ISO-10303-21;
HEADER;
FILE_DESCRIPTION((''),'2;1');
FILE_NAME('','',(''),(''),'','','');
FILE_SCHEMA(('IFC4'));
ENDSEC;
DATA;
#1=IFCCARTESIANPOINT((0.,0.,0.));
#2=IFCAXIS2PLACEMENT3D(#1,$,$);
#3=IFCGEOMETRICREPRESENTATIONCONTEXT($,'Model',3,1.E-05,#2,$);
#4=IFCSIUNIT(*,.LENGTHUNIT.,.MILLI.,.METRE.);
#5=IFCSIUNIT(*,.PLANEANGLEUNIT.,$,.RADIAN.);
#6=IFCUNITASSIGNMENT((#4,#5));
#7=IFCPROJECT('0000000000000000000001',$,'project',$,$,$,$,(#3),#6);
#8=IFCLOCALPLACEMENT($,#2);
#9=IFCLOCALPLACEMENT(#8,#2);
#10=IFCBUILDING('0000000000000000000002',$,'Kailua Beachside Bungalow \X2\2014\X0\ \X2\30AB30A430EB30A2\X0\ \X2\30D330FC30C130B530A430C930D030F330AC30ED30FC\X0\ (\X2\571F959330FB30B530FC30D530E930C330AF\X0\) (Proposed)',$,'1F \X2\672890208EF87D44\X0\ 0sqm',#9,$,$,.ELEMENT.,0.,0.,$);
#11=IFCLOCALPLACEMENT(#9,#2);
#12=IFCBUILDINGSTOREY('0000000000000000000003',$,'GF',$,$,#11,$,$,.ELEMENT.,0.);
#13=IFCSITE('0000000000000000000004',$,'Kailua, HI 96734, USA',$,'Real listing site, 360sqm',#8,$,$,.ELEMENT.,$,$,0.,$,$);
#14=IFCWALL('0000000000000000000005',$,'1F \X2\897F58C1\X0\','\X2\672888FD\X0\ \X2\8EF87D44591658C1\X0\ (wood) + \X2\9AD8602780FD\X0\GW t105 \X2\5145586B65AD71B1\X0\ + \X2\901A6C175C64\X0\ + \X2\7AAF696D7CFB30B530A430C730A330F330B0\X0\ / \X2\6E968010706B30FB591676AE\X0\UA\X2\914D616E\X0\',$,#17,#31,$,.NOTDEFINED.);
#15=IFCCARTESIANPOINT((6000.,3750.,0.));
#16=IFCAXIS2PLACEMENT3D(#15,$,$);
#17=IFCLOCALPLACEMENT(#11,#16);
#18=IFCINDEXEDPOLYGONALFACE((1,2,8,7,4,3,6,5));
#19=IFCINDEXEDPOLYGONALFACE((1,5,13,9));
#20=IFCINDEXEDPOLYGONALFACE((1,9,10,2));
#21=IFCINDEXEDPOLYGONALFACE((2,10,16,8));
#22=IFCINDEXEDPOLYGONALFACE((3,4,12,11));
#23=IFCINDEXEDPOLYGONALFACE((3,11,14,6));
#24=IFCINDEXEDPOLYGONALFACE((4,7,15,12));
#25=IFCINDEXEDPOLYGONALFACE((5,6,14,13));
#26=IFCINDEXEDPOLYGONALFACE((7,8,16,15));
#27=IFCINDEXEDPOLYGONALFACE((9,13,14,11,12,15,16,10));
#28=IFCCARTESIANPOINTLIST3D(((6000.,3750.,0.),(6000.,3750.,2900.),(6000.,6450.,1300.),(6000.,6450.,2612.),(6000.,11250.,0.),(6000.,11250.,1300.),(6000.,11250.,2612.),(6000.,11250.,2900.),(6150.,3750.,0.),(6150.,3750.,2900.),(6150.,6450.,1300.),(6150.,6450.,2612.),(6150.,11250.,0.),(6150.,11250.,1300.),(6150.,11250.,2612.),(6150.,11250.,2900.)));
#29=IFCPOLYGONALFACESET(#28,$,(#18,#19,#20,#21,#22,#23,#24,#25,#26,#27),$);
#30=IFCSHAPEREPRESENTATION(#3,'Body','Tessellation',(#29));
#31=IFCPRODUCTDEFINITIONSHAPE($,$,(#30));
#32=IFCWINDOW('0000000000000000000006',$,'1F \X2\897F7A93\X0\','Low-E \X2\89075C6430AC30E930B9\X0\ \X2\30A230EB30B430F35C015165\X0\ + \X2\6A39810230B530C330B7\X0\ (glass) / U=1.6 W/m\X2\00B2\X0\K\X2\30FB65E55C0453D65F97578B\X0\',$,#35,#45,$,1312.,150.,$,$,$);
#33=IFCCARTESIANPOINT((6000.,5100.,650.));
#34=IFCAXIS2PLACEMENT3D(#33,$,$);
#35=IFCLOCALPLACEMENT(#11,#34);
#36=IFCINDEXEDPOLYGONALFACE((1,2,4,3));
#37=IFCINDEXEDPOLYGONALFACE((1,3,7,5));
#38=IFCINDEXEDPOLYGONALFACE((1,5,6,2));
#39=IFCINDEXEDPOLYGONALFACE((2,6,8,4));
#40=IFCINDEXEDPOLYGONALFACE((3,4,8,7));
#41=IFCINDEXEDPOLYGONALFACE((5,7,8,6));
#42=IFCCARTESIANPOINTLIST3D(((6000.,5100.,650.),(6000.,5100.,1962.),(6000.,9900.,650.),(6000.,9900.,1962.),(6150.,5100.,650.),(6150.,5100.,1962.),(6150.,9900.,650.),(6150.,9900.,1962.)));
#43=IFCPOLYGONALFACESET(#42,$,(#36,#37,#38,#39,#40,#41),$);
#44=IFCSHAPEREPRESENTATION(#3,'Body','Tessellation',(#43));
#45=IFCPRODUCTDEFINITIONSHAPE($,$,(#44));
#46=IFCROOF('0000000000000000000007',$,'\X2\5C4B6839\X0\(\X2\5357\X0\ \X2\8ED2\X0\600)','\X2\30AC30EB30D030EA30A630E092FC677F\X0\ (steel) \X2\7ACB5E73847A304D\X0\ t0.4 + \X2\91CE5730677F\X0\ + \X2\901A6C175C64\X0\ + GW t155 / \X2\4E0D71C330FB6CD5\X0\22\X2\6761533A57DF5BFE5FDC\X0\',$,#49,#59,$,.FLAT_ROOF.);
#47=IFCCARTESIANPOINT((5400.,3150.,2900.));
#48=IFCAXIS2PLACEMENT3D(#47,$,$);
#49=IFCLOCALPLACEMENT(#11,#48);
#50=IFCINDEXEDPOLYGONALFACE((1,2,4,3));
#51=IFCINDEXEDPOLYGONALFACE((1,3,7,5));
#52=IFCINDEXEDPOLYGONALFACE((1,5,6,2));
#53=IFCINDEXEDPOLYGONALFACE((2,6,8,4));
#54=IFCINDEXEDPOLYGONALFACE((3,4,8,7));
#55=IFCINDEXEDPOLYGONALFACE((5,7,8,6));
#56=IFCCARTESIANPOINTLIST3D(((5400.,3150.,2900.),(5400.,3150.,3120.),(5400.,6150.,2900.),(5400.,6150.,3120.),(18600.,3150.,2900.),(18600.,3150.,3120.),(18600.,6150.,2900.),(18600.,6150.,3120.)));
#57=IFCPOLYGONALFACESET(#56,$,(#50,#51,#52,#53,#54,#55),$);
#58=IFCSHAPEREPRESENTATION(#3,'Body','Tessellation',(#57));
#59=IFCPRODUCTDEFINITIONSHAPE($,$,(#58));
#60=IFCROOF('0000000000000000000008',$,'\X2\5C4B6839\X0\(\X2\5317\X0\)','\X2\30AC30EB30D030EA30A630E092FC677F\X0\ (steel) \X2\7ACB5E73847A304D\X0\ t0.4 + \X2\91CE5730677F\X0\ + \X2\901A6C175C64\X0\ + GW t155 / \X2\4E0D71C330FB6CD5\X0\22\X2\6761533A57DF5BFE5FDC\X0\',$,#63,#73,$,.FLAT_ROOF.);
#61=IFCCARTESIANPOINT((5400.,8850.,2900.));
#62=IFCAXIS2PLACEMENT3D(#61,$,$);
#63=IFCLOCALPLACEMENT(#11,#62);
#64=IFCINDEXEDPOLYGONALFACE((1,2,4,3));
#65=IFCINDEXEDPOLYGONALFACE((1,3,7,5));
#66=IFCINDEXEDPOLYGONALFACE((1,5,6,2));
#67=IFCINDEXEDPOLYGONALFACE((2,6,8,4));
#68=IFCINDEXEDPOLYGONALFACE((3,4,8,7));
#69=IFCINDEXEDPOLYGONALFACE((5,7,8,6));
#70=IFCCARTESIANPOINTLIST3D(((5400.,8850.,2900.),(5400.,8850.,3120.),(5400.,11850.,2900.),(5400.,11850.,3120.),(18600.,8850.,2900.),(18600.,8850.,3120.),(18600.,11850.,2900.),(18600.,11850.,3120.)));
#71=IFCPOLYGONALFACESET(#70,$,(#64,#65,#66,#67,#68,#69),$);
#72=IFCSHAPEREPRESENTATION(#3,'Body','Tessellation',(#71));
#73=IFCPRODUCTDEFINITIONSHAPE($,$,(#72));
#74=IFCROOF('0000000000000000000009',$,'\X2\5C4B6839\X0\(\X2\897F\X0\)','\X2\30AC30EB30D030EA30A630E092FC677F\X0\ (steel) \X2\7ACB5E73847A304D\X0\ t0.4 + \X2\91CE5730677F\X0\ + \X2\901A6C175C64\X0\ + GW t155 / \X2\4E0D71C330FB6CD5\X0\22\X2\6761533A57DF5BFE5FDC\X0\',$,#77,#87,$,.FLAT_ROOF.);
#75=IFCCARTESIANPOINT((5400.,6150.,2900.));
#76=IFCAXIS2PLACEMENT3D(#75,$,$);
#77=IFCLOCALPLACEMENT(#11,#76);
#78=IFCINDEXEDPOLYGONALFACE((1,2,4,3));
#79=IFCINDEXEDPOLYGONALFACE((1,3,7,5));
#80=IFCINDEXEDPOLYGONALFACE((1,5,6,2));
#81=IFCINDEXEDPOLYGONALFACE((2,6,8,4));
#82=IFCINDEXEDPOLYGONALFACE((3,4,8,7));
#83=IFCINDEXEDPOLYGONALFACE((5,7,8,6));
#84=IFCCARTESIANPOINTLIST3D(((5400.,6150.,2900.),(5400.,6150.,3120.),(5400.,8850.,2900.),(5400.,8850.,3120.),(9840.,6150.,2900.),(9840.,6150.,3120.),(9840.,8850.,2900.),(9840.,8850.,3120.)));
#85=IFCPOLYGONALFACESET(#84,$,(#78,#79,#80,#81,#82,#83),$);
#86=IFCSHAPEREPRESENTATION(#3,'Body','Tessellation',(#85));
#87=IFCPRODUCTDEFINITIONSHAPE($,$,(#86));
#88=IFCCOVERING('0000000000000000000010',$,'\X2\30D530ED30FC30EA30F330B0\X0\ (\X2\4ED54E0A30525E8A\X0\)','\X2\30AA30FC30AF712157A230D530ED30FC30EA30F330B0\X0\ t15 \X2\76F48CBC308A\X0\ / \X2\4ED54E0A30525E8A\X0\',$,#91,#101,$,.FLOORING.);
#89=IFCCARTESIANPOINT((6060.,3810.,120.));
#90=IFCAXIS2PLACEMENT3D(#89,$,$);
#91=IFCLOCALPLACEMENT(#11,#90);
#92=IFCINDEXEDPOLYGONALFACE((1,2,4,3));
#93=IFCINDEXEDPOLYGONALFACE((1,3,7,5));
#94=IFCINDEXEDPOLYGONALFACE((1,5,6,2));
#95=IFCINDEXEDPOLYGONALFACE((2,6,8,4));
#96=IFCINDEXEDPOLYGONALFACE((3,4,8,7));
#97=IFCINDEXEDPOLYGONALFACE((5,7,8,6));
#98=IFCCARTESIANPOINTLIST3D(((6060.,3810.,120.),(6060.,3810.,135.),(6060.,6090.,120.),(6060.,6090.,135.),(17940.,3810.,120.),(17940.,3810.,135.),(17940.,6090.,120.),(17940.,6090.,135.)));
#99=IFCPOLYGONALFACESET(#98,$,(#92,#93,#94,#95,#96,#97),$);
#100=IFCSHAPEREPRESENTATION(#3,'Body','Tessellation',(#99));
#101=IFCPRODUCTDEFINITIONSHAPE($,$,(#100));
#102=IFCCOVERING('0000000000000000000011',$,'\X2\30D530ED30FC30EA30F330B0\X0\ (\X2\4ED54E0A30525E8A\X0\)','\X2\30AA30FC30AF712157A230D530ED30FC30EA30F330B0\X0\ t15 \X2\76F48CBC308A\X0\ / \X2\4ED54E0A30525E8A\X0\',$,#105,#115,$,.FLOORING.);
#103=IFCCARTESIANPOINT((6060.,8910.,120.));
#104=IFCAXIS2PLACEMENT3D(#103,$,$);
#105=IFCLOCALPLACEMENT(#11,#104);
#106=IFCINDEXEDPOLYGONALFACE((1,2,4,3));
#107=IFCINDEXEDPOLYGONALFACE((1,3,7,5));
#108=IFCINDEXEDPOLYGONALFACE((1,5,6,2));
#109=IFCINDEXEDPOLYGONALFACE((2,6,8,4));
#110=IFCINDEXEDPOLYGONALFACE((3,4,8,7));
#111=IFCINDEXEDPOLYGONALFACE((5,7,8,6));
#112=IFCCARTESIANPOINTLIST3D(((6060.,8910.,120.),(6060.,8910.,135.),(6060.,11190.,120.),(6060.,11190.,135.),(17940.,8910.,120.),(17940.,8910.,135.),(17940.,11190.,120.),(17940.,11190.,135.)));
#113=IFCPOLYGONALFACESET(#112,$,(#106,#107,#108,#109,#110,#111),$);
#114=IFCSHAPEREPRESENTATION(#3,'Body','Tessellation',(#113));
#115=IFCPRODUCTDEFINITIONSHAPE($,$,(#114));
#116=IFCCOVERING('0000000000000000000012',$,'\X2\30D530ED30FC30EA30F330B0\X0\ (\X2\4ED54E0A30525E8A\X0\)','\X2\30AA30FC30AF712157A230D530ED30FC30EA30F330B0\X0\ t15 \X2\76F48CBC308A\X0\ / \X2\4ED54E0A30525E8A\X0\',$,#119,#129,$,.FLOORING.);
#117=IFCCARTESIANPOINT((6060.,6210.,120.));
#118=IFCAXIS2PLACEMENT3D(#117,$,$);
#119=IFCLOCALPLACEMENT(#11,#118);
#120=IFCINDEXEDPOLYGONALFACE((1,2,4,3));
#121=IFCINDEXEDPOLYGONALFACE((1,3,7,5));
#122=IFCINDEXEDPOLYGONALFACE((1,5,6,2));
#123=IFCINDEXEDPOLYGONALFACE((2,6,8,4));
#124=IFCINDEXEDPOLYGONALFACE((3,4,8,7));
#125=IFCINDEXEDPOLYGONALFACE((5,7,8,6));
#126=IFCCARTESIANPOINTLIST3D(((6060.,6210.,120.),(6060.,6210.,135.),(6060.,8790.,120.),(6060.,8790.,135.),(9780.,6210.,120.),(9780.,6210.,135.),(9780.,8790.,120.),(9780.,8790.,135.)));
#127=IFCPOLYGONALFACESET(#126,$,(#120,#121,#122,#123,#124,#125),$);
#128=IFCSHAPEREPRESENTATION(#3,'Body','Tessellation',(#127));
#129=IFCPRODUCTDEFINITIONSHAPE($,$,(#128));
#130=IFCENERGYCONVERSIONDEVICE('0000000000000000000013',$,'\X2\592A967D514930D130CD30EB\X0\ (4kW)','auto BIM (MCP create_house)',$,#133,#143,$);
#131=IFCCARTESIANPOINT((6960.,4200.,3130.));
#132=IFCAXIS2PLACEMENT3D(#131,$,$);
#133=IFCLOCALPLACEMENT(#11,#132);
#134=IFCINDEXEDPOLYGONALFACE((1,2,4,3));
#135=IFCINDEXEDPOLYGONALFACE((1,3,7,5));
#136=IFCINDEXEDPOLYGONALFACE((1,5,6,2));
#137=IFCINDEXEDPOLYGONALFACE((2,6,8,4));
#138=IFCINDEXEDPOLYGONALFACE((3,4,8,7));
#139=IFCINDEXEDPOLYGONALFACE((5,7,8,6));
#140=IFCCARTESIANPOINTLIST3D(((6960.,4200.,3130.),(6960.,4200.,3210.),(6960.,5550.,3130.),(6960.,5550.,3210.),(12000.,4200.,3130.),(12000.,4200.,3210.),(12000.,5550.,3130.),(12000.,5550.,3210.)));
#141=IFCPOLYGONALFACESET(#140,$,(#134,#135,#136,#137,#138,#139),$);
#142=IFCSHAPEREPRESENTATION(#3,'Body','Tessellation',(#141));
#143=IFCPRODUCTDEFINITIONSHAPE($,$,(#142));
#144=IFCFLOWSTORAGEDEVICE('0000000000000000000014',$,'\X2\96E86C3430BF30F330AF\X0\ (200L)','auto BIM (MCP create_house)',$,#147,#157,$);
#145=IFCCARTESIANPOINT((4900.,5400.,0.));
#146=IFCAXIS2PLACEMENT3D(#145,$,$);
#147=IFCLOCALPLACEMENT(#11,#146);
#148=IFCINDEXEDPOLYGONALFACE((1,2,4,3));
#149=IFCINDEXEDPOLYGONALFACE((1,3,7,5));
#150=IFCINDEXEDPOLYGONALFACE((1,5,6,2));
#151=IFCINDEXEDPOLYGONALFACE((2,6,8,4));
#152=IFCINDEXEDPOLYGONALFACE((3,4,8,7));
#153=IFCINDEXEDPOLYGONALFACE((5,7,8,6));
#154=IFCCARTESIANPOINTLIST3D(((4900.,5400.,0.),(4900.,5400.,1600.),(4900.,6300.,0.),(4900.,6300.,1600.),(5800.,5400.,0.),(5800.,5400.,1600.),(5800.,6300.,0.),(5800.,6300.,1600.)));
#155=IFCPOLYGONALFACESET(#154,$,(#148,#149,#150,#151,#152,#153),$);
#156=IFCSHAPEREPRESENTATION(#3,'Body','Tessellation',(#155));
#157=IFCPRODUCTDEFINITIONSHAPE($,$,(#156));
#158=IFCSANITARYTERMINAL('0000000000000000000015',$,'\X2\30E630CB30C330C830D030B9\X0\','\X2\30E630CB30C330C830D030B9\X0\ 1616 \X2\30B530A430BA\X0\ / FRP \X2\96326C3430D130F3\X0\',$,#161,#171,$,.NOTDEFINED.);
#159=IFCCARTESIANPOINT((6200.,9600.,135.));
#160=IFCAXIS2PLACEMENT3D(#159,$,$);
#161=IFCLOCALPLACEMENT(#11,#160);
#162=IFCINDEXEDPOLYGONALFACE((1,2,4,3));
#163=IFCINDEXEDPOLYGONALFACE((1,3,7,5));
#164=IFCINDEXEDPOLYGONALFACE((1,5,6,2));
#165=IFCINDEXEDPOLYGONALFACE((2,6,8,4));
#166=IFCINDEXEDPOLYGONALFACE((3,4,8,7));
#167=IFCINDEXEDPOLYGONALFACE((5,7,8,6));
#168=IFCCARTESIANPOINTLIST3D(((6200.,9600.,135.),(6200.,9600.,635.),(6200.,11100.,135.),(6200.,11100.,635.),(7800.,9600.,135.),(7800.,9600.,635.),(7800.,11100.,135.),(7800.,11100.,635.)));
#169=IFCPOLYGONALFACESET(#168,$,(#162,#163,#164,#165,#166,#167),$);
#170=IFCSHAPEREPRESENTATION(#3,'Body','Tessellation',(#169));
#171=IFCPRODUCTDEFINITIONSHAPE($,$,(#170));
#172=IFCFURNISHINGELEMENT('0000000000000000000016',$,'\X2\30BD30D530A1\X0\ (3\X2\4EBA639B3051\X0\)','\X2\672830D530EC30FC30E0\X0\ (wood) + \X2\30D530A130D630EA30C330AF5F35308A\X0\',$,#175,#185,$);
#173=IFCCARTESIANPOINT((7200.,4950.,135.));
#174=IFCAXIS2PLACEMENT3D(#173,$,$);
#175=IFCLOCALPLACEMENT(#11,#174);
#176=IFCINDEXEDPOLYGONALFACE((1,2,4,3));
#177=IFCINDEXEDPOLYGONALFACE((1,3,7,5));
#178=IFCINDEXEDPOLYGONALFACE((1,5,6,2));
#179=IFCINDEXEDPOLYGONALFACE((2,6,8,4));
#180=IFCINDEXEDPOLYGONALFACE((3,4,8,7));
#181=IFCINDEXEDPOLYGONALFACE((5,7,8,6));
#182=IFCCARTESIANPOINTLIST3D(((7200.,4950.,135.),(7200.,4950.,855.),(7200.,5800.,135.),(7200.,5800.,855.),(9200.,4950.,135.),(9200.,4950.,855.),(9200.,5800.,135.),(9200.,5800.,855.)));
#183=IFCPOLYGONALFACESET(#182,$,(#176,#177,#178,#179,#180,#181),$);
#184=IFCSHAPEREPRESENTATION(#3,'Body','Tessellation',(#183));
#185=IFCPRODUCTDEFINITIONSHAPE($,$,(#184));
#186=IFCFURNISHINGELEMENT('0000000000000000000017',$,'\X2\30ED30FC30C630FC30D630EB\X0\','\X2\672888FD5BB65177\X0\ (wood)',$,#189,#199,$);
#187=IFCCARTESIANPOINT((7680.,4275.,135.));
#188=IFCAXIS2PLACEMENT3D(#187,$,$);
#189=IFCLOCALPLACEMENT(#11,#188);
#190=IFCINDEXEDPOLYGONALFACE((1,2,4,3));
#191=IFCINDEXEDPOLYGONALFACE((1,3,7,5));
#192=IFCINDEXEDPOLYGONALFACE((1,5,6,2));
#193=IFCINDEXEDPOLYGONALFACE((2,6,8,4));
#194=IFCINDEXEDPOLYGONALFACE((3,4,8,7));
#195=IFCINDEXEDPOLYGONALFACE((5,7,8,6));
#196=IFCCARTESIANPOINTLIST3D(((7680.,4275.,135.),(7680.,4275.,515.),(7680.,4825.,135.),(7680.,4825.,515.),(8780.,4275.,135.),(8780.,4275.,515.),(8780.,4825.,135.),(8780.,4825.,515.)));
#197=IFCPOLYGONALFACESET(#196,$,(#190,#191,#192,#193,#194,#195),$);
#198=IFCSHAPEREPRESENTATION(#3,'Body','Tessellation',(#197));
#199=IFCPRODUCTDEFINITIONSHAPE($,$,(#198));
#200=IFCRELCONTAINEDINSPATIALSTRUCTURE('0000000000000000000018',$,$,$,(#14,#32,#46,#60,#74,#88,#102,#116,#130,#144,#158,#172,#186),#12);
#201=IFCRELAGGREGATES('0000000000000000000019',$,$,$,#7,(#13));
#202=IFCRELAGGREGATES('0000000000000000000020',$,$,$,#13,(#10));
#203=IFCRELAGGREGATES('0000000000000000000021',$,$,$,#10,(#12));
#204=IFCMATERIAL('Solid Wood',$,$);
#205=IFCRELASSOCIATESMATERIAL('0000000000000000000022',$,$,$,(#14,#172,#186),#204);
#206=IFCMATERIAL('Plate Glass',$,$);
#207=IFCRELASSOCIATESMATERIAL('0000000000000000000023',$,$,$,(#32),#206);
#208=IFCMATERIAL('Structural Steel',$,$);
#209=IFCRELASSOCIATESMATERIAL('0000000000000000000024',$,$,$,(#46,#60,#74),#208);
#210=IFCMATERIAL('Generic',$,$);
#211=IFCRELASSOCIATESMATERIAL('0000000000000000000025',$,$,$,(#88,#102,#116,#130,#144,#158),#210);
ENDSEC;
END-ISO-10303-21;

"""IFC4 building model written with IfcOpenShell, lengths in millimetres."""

from ifc_helpers import new_model, si_unit, frame, frame_2d, origin, place, context, project, spatial, rectangle, extrude, material, element, fill, save


model = new_model("IFC4")

# Units and contexts
model_context = context("Model", 3, precision=1e-05, world=origin())
ifc_project = project(units=[si_unit("LENGTHUNIT", "METRE", prefix="MILLI"), si_unit("PLANEANGLEUNIT", "RADIAN")], contexts=[model_context])

# Site, building, storey
site_placement = place(None, origin())
site = spatial("IfcSite", under=ifc_project, at=site_placement, Name="Kailua, HI 96734, USA", ObjectType="Real listing site, 360sqm", CompositionType="ELEMENT", RefElevation=0.0)
building_placement = place(site_placement, origin())
building = spatial("IfcBuilding", under=site, at=building_placement, Name="Kailua Beachside Bungalow — カイルア ビーチサイドバンガロー (土間・サーフラック) (Proposed)", ObjectType="1F 木造軸組 0sqm", CompositionType="ELEMENT", ElevationOfRefHeight=0.0, ElevationOfTerrain=0.0)
storey_placement = place(building_placement, origin())
storey = spatial("IfcBuildingStorey", under=building, at=storey_placement, Name="GF", CompositionType="ELEMENT", Elevation=0.0)

# Shared definitions
ifc_material_1 = material(Name="Solid Wood")

# Shared definitions
ifc_material_2 = material(Name="Plate Glass")

# Wall, opening, window
wall_1_placement = place(storey_placement, frame((6000.0, 3750.0, 0.0)))
wall_1 = element("IfcWall", 1, at=wall_1_placement, inside=storey, material=ifc_material_1, Name="1F 西壁", Description="木製 軸組外壁 (wood) + 高性能GW t105 充填断熱 + 通気層 + 窯業系サイディング / 準耐火・外皮UA配慮", PredefinedType="NOTDEFINED", context=model_context, shape_type="SweptSolid", body=[
    extrude(rectangle(XDim=150.0, YDim=7500.0, at=frame_2d((75.0, 3750.0))), frame((6000.0, 3750.0, 0.0)), (0.0, 0.0, 1.0), 2900.0),
])
opening_1_placement = place(storey_placement, frame((6000.0, 5100.0, 650.0)))
opening_1 = element("IfcOpeningElement", 2, at=opening_1_placement, cuts=wall_1, PredefinedType="NOTDEFINED", context=model_context, shape_type="SweptSolid", body=[
    extrude(rectangle(XDim=150.0, YDim=4800.0, at=frame_2d((75.0, 2400.0))), frame((6000.0, 5100.0, 650.0)), (0.0, 0.0, 1.0), 1312.0),
])
window_1_placement = place(storey_placement, frame((6000.0, 5100.0, 650.0)))
window_1 = element("IfcWindow", 3, at=window_1_placement, inside=storey, material=ifc_material_2, Name="1F 西窓", Description="Low-E 複層ガラス アルゴン封入 + 樹脂サッシ (glass) / U=1.6 W/m²K・日射取得型", OverallHeight=1312.0, OverallWidth=150.0, context=model_context, shape_type="SweptSolid", body=[
    extrude(rectangle(XDim=150.0, YDim=4800.0, at=frame_2d((75.0, 2400.0))), frame((6000.0, 5100.0, 650.0)), (0.0, 0.0, 1.0), 1312.0),
])
fill(opening_1, window_1)

# Roofs
ifc_material_3 = material(Name="Structural Steel")
roof_1_placement = place(storey_placement, frame((5400.0, 3150.0, 2900.0)))
element("IfcRoof", 4, at=roof_1_placement, inside=storey, material=ifc_material_3, Name="屋根(南 軒600)", Description="ガルバリウム鋼板 (steel) 立平葺き t0.4 + 野地板 + 通気層 + GW t155 / 不燃・法22条区域対応", PredefinedType="FLAT_ROOF", context=model_context, shape_type="SweptSolid", body=[
    extrude(rectangle(XDim=13200.0, YDim=3000.0, at=frame_2d((6600.0, 1500.0))), frame((5400.0, 3150.0, 2900.0)), (0.0, 0.0, 1.0), 220.0),
])
roof_2_placement = place(storey_placement, frame((5400.0, 8850.0, 2900.0)))
element("IfcRoof", 5, at=roof_2_placement, inside=storey, material=ifc_material_3, Name="屋根(北)", Description="ガルバリウム鋼板 (steel) 立平葺き t0.4 + 野地板 + 通気層 + GW t155 / 不燃・法22条区域対応", PredefinedType="FLAT_ROOF", context=model_context, shape_type="SweptSolid", body=[
    extrude(rectangle(XDim=13200.0, YDim=3000.0, at=frame_2d((6600.0, 1500.0))), frame((5400.0, 8850.0, 2900.0)), (0.0, 0.0, 1.0), 220.0),
])
roof_3_placement = place(storey_placement, frame((5400.0, 6150.0, 2900.0)))
element("IfcRoof", 6, at=roof_3_placement, inside=storey, material=ifc_material_3, Name="屋根(西)", Description="ガルバリウム鋼板 (steel) 立平葺き t0.4 + 野地板 + 通気層 + GW t155 / 不燃・法22条区域対応", PredefinedType="FLAT_ROOF", context=model_context, shape_type="SweptSolid", body=[
    extrude(rectangle(XDim=4440.0, YDim=2700.0, at=frame_2d((2220.0, 1350.0))), frame((5400.0, 6150.0, 2900.0)), (0.0, 0.0, 1.0), 220.0),
])

# Coverings
ifc_material_4 = material(Name="Generic")
covering_1_placement = place(storey_placement, frame((6060.0, 3810.0, 120.0)))
element("IfcCovering", 7, at=covering_1_placement, inside=storey, material=ifc_material_4, Name="フローリング (仕上げ床)", Description="オーク無垢フローリング t15 直貼り / 仕上げ床", PredefinedType="FLOORING", context=model_context, shape_type="SweptSolid", body=[
    extrude(rectangle(XDim=11880.0, YDim=2280.0, at=frame_2d((5940.0, 1140.0))), frame((6060.0, 3810.0, 120.0)), (0.0, 0.0, 1.0), 15.0),
])
covering_2_placement = place(storey_placement, frame((6060.0, 8910.0, 120.0)))
element("IfcCovering", 8, at=covering_2_placement, inside=storey, material=ifc_material_4, Name="フローリング (仕上げ床)", Description="オーク無垢フローリング t15 直貼り / 仕上げ床", PredefinedType="FLOORING", context=model_context, shape_type="SweptSolid", body=[
    extrude(rectangle(XDim=11880.0, YDim=2280.0, at=frame_2d((5940.0, 1140.0))), frame((6060.0, 8910.0, 120.0)), (0.0, 0.0, 1.0), 15.0),
])
covering_3_placement = place(storey_placement, frame((6060.0, 6210.0, 120.0)))
element("IfcCovering", 9, at=covering_3_placement, inside=storey, material=ifc_material_4, Name="フローリング (仕上げ床)", Description="オーク無垢フローリング t15 直貼り / 仕上げ床", PredefinedType="FLOORING", context=model_context, shape_type="SweptSolid", body=[
    extrude(rectangle(XDim=3720.0, YDim=2580.0, at=frame_2d((1860.0, 1290.0))), frame((6060.0, 6210.0, 120.0)), (0.0, 0.0, 1.0), 15.0),
])

# Energy conversion device
energy_conversion_device_placement = place(storey_placement, frame((6960.0, 4200.0, 3130.0)))
element("IfcEnergyConversionDevice", 10, at=energy_conversion_device_placement, inside=storey, material=ifc_material_4, Name="太陽光パネル (4kW)", Description="auto BIM (MCP create_house)", context=model_context, shape_type="SweptSolid", body=[
    extrude(rectangle(XDim=5040.0, YDim=1350.0, at=frame_2d((2520.0, 675.0))), frame((6960.0, 4200.0, 3130.0)), (0.0, 0.0, 1.0), 80.0),
])

# Flow storage device
flow_storage_device_placement = place(storey_placement, frame((4900.0, 5400.0, 0.0)))
element("IfcFlowStorageDevice", 11, at=flow_storage_device_placement, inside=storey, material=ifc_material_4, Name="雨水タンク (200L)", Description="auto BIM (MCP create_house)", context=model_context, shape_type="SweptSolid", body=[
    extrude(rectangle(XDim=900.0, YDim=900.0, at=frame_2d((450.0, 450.0))), frame((4900.0, 5400.0, 0.0)), (0.0, 0.0, 1.0), 1600.0),
])

# Sanitary terminal
sanitary_terminal_placement = place(storey_placement, frame((6200.0, 9600.0, 135.0)))
element("IfcSanitaryTerminal", 12, at=sanitary_terminal_placement, inside=storey, material=ifc_material_4, Name="ユニットバス", Description="ユニットバス 1616 サイズ / FRP 防水パン", PredefinedType="NOTDEFINED", context=model_context, shape_type="SweptSolid", body=[
    extrude(rectangle(XDim=1600.0, YDim=1500.0, at=frame_2d((800.0, 750.0))), frame((6200.0, 9600.0, 135.0)), (0.0, 0.0, 1.0), 500.0),
])

# Furnishing elements
furnishing_1_placement = place(storey_placement, frame((7200.0, 4950.0, 135.0)))
element("IfcFurnishingElement", 13, at=furnishing_1_placement, inside=storey, material=ifc_material_1, Name="ソファ (3人掛け)", Description="木フレーム (wood) + ファブリック張り", context=model_context, shape_type="SweptSolid", body=[
    extrude(rectangle(XDim=2000.0, YDim=850.0, at=frame_2d((1000.0, 425.0))), frame((7200.0, 4950.0, 135.0)), (0.0, 0.0, 1.0), 720.0),
])
furnishing_2_placement = place(storey_placement, frame((7680.0, 4275.0, 135.0)))
element("IfcFurnishingElement", 14, at=furnishing_2_placement, inside=storey, material=ifc_material_1, Name="ローテーブル", Description="木製家具 (wood)", context=model_context, shape_type="SweptSolid", body=[
    extrude(rectangle(XDim=1100.0, YDim=550.0, at=frame_2d((550.0, 275.0))), frame((7680.0, 4275.0, 135.0)), (0.0, 0.0, 1.0), 380.0),
])

save(model, "model.ifc")
